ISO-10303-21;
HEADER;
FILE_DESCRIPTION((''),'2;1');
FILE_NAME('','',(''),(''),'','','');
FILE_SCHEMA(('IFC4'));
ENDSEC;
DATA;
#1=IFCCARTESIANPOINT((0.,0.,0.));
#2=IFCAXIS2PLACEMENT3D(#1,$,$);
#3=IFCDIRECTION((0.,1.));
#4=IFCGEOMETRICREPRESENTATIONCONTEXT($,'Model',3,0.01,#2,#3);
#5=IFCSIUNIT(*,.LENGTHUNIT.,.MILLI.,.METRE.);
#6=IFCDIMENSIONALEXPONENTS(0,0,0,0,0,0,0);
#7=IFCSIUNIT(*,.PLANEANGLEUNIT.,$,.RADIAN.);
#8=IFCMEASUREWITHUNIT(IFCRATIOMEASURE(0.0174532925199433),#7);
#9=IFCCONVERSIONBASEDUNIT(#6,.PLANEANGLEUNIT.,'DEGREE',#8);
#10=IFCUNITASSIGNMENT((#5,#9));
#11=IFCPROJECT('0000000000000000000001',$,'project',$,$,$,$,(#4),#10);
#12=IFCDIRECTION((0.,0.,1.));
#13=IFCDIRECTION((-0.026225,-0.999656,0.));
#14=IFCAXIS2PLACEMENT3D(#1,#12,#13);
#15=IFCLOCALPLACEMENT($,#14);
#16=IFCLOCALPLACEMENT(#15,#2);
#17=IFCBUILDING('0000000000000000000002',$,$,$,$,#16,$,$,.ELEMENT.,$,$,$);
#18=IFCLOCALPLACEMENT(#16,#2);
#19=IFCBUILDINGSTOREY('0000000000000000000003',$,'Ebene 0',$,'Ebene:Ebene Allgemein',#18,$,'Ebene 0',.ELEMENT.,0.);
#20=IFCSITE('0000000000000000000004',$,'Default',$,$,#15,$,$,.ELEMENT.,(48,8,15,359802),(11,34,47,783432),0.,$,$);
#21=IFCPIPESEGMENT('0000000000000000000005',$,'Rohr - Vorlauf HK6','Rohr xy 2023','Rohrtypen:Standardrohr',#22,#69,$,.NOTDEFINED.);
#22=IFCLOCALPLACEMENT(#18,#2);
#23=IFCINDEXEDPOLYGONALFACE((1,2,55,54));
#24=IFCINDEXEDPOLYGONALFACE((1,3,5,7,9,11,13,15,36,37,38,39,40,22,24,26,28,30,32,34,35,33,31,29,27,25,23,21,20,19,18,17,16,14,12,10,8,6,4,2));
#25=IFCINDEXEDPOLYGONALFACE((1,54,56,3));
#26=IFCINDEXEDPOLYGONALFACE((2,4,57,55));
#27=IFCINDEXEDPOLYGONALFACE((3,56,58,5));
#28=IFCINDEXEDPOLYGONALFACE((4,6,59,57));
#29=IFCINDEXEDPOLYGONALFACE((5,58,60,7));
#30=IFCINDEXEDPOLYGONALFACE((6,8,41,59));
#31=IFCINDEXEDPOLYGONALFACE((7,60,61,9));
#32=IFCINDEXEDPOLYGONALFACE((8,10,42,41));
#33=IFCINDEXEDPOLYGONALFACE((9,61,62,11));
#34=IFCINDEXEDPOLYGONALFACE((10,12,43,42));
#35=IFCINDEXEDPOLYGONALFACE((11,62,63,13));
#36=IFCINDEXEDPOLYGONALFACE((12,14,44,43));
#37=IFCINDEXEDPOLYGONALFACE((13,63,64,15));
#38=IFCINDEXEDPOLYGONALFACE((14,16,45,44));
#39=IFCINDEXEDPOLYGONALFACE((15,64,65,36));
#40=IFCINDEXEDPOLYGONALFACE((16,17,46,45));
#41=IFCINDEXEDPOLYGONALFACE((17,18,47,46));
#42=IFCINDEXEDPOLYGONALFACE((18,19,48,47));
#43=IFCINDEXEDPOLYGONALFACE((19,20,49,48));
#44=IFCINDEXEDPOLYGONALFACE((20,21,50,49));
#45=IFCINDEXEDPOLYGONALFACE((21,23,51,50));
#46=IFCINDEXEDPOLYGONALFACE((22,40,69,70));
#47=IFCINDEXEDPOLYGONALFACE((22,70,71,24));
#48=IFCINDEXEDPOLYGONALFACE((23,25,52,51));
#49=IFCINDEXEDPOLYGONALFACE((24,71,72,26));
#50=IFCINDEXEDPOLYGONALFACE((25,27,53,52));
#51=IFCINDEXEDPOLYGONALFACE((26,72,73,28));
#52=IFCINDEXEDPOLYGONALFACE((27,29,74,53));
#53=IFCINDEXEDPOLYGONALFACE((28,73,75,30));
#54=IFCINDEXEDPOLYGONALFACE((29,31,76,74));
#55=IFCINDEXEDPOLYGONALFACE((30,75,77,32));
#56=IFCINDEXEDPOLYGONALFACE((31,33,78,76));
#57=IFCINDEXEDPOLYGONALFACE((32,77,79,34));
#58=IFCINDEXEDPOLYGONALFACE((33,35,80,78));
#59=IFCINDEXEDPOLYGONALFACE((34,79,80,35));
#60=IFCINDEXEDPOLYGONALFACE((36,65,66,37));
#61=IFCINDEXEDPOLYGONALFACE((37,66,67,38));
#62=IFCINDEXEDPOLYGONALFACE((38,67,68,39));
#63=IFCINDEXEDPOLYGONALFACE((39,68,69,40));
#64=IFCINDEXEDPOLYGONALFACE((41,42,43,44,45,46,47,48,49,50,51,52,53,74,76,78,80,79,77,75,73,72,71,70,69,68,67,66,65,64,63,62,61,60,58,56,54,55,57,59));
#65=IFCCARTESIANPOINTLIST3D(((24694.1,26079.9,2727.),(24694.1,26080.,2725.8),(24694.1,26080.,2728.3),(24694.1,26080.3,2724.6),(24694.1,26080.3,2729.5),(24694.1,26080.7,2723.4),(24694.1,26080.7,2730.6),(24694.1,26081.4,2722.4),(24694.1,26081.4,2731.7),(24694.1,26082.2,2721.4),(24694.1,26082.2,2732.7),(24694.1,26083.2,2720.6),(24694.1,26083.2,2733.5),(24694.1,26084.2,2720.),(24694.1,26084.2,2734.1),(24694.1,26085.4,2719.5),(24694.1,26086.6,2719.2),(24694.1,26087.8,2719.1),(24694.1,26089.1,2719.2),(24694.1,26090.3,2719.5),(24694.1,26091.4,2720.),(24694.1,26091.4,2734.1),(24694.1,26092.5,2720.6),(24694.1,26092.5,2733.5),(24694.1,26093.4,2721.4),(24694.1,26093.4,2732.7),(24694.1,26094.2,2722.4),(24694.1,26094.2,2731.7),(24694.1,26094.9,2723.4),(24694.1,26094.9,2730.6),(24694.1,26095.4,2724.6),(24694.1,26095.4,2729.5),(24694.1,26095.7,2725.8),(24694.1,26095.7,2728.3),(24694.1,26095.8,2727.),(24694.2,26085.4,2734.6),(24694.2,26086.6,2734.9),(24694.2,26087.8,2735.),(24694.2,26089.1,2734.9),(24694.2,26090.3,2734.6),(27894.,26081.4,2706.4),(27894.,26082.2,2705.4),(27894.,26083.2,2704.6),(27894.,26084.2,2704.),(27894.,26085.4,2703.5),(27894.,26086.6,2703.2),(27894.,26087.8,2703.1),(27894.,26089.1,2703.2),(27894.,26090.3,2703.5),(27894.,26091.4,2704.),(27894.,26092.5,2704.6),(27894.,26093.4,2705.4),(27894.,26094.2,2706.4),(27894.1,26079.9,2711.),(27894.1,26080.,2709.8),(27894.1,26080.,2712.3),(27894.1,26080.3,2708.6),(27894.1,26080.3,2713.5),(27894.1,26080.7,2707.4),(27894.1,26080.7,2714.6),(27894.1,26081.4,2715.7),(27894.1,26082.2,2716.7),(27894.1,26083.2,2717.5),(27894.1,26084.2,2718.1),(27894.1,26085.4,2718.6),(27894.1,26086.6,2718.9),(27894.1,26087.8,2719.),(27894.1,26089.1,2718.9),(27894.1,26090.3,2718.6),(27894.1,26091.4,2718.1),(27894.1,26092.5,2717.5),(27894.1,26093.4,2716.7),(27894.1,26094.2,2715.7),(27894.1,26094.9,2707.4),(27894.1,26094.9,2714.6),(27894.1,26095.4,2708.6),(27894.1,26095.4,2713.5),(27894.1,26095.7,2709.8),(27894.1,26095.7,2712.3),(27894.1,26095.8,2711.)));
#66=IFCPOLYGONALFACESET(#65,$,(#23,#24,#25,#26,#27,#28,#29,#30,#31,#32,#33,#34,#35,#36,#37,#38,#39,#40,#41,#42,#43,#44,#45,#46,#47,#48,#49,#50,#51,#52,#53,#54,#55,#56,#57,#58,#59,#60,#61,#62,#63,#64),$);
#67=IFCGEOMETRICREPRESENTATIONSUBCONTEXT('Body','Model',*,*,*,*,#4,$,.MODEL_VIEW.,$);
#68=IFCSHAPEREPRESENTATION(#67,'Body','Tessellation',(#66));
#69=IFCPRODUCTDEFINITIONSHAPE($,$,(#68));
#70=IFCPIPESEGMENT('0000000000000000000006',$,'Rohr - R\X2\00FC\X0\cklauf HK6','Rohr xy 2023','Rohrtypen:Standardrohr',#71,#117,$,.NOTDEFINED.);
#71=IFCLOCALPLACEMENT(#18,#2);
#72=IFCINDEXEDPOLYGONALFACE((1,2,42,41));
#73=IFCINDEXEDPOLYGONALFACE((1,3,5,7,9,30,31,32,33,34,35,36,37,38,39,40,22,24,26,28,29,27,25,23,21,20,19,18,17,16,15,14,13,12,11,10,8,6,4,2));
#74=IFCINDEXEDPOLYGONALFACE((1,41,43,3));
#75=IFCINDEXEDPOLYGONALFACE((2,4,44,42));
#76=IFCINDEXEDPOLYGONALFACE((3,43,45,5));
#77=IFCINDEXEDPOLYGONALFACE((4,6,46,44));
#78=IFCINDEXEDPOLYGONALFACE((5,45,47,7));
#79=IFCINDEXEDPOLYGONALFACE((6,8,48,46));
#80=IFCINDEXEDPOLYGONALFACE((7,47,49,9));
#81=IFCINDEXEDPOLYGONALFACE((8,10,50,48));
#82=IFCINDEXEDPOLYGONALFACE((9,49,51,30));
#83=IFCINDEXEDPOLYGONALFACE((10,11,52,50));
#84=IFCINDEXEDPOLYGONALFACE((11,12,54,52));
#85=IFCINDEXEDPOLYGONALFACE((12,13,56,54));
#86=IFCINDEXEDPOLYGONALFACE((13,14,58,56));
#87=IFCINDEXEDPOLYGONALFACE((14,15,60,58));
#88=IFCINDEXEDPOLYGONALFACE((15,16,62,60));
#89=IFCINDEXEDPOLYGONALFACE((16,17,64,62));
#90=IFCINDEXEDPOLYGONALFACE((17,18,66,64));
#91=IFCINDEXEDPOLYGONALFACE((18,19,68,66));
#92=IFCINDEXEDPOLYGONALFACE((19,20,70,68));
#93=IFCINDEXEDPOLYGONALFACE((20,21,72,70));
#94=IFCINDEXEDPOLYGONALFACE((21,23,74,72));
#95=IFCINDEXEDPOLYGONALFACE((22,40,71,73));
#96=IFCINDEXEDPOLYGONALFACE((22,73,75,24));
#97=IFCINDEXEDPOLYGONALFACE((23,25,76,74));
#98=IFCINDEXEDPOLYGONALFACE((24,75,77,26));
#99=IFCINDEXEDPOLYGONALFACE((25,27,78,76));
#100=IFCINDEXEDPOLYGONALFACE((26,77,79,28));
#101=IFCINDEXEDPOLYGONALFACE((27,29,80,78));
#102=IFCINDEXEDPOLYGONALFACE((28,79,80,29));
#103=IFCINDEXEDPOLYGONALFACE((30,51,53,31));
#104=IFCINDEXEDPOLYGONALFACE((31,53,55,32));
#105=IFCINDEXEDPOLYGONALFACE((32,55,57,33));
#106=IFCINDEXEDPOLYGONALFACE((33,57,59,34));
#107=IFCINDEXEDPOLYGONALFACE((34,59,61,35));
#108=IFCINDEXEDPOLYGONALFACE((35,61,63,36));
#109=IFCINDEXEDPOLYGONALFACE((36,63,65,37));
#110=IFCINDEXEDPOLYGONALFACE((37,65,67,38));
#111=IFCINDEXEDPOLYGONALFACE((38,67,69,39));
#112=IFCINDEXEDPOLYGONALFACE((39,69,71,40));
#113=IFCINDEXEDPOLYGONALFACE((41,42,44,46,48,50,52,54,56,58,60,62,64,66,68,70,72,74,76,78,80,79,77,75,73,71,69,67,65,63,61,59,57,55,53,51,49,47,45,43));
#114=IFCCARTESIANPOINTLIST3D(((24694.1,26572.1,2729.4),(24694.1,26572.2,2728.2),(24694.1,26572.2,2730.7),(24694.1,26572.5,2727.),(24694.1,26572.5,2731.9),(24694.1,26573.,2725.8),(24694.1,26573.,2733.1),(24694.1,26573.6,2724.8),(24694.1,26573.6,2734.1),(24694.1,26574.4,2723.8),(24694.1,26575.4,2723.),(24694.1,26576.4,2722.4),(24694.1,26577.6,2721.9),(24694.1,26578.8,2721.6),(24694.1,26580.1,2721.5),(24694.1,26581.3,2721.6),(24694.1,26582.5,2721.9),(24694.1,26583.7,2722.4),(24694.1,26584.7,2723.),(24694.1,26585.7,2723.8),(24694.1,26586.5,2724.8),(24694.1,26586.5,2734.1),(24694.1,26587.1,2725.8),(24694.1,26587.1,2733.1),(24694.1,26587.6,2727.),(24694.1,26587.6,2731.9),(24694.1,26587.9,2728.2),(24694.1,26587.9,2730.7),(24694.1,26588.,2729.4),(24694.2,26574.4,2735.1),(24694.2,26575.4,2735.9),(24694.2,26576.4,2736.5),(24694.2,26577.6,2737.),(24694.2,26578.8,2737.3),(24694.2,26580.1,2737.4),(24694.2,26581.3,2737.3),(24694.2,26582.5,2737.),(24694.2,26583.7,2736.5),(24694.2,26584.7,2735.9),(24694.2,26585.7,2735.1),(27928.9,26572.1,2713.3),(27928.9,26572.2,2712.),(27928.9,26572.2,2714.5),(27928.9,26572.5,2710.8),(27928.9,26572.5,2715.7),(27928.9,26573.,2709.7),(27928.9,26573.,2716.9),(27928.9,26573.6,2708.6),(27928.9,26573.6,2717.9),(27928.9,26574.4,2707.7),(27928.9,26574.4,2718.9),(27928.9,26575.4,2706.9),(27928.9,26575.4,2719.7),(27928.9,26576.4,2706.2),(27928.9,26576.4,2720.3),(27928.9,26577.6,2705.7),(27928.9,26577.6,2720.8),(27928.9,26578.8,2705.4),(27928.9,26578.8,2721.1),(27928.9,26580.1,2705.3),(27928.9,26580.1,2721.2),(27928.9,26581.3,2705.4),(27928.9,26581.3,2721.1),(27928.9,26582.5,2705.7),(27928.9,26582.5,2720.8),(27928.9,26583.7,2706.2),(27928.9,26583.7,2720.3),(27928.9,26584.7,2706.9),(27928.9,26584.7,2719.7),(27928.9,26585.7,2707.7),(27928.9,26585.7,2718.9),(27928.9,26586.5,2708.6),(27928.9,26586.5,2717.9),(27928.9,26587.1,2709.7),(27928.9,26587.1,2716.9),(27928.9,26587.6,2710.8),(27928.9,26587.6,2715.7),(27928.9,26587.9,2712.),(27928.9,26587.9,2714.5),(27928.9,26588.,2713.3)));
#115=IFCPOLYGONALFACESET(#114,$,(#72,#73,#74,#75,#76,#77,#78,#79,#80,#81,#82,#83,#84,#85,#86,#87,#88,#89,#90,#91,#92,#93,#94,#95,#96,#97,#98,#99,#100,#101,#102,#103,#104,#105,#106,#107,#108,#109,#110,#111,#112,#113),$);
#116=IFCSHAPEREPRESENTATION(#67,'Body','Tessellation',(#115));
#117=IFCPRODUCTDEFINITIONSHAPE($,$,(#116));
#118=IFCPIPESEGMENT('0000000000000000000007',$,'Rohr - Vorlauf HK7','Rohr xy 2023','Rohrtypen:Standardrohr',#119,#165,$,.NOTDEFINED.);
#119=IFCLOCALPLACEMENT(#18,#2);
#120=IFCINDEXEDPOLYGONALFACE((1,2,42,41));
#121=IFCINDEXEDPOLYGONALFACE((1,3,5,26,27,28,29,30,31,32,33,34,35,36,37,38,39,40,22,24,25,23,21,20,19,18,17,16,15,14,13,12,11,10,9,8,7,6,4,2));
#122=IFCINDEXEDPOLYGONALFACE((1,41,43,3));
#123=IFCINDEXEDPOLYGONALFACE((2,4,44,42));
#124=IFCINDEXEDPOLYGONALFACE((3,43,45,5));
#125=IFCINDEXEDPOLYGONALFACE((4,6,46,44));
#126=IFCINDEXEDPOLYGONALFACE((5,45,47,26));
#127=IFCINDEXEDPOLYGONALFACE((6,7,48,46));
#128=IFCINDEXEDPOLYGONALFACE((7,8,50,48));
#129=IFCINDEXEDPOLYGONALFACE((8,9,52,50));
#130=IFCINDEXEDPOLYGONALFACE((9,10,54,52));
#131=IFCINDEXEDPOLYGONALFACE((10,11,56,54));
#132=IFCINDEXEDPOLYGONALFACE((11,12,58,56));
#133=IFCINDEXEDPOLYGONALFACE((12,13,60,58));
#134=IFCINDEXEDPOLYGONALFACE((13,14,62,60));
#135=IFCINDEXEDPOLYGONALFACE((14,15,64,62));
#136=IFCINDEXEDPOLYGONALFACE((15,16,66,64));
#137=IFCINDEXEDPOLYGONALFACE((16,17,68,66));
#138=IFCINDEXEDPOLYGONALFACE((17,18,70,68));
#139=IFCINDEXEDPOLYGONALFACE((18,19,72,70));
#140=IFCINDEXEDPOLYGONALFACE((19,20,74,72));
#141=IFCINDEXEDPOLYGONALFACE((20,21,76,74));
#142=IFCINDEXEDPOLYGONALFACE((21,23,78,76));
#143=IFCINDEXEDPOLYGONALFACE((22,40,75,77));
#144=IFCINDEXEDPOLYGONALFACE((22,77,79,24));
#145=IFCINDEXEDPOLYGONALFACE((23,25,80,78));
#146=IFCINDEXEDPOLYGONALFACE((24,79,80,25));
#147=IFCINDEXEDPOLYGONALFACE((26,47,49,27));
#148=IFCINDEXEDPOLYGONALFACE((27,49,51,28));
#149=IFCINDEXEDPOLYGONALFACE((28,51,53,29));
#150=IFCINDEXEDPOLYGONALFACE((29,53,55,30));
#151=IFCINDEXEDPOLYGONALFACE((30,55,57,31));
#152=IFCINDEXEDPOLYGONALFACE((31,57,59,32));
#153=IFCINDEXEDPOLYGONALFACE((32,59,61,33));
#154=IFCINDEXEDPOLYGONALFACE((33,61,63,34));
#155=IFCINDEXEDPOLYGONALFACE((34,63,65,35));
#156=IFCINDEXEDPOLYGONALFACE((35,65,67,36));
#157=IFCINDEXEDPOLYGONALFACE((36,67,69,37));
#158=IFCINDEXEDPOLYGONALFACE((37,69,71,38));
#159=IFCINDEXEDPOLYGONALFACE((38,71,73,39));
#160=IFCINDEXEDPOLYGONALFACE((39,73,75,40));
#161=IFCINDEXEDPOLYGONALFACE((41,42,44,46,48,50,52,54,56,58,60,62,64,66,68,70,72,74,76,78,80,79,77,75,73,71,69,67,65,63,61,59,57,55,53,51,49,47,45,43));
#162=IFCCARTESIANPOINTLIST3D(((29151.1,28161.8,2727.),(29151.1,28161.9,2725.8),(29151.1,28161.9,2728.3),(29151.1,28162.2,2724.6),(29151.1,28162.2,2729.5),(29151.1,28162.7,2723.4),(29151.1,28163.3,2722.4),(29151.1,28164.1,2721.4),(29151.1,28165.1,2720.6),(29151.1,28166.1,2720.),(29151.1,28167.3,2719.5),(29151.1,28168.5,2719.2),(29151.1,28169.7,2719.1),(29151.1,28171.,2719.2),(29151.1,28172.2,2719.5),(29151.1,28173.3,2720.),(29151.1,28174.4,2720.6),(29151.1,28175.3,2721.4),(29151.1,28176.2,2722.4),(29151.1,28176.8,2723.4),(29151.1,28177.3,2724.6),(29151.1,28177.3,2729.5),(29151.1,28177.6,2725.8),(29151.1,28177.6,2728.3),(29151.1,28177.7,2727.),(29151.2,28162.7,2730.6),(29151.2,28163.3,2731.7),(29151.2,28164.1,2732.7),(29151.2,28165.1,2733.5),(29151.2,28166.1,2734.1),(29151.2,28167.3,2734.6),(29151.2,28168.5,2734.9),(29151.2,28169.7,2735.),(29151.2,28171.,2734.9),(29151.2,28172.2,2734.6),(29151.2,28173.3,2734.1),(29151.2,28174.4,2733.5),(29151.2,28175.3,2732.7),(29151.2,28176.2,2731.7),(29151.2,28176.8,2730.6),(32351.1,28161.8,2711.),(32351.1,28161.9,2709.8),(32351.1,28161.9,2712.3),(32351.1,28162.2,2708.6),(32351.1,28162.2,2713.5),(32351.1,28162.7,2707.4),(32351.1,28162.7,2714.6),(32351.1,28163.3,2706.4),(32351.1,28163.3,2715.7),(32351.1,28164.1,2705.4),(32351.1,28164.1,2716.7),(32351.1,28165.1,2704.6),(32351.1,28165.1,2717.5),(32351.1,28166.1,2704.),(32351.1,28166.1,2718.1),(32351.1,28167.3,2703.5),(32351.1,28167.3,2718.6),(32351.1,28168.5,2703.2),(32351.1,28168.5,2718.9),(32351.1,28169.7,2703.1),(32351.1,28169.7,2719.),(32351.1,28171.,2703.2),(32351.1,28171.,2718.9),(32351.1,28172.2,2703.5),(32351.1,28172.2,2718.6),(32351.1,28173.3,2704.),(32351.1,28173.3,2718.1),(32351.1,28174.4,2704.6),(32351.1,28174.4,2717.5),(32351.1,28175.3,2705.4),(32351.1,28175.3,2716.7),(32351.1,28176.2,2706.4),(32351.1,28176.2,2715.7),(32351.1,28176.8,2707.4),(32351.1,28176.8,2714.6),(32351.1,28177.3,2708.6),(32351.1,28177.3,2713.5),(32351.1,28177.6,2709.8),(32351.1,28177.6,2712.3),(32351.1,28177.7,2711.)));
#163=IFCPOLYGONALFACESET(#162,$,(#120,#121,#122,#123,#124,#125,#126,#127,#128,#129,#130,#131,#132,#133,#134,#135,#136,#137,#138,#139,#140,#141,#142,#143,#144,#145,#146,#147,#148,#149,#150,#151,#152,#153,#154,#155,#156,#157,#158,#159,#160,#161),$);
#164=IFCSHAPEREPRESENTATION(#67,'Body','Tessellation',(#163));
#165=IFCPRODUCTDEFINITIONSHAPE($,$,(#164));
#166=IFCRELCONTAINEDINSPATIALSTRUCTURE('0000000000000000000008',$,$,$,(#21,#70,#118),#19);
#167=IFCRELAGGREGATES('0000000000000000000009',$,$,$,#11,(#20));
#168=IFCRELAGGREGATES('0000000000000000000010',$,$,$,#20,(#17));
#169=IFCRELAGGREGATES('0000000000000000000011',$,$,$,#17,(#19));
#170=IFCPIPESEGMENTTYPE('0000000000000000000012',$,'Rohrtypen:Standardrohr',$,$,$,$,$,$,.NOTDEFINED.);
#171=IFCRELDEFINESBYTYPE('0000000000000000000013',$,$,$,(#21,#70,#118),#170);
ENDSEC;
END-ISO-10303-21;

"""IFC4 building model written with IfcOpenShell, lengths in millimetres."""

from ifc_helpers import new_model, entity, si_unit, converted_unit, direction, frame, origin, place, context, subcontext, project, spatial, indexed_curve, outline, extrude, type_object, element, save


model = new_model("IFC4")

# Units and contexts
model_context = context("Model", 3, precision=0.01, world=origin(), true_north=direction((0.0, 1.0)))
body_context = subcontext(model_context, "Body", "Model", "MODEL_VIEW")
ifc_project = project(units=[si_unit("LENGTHUNIT", "METRE", prefix="MILLI"), converted_unit("PLANEANGLEUNIT", "DEGREE", entity("IfcRatioMeasure", 0.0174532925199433), si_unit("PLANEANGLEUNIT", "RADIAN"), dimensions=[0, 0, 0, 0, 0, 0, 0])], contexts=[model_context])

# Site, building, storey
site_placement = place(None, frame((0.0, 0.0, 0.0), z_axis=(0.0, 0.0, 1.0), x_axis=(-0.026225, -0.999656, 0.0)))
site = spatial("IfcSite", under=ifc_project, at=site_placement, Name="Default", CompositionType="ELEMENT", RefLatitude=(48, 8, 15, 359802), RefLongitude=(11, 34, 47, 783432), RefElevation=0.0)
building_placement = place(site_placement, origin())
building = spatial("IfcBuilding", under=site, at=building_placement, CompositionType="ELEMENT")
storey_placement = place(building_placement, origin())
storey = spatial("IfcBuildingStorey", under=building, at=storey_placement, Name="Ebene 0", ObjectType="Ebene:Ebene Allgemein", LongName="Ebene 0", CompositionType="ELEMENT", Elevation=0.0)

# Pipe segments
pipe_segment_type = type_object("IfcPipeSegmentType", Name="Rohrtypen:Standardrohr", PredefinedType="NOTDEFINED")
pipe_segment_1_placement = place(storey_placement, origin())
element("IfcPipeSegment", 1, at=pipe_segment_1_placement, inside=storey, type_object=pipe_segment_type, Name="Rohr - Vorlauf HK6", Description="Rohr xy 2023", ObjectType="Rohrtypen:Standardrohr", PredefinedType="NOTDEFINED", context=body_context, shape_type="SweptSolid", body=[
    extrude(outline(indexed_curve([(7.9, 0.0), (7.8, 1.2), (7.6, 2.5), (7.1, 3.6), (6.4, 4.7), (5.6, 5.6), (4.7, 6.4), (3.6, 7.1), (2.5, 7.6), (1.2, 7.8), (0.0, 7.9), (-1.2, 7.8), (-2.5, 7.6), (-3.6, 7.1), (-4.7, 6.4), (-5.6, 5.6), (-6.4, 4.7), (-7.1, 3.6), (-7.6, 2.5), (-7.8, 1.2), (-7.9, 0.0), (-7.8, -1.2), (-7.6, -2.5), (-7.1, -3.6), (-6.4, -4.7), (-5.6, -5.6), (-4.7, -6.4), (-3.6, -7.1), (-2.5, -7.6), (-1.2, -7.8), (0.0, -7.9), (1.2, -7.8), (2.5, -7.6), (3.6, -7.1), (4.7, -6.4), (5.6, -5.6), (6.4, -4.7), (7.1, -3.6), (7.6, -2.5), (7.8, -1.2), (7.9, 0.0)], self_intersect=False)), frame((27894.1, 26087.8, 2711.0), z_axis=(-0.999988, 0.0, 0.005), x_axis=(0.0, 1.0, 0.0)), (0.0, 0.0, 1.0), 3200.0),
])
pipe_segment_2_placement = place(storey_placement, origin())
element("IfcPipeSegment", 2, at=pipe_segment_2_placement, inside=storey, type_object=pipe_segment_type, Name="Rohr - Rücklauf HK6", Description="Rohr xy 2023", ObjectType="Rohrtypen:Standardrohr", PredefinedType="NOTDEFINED", context=body_context, shape_type="SweptSolid", body=[
    extrude(outline(indexed_curve([(7.9, 0.0), (7.8, 1.2), (7.6, 2.5), (7.1, 3.6), (6.4, 4.7), (5.6, 5.6), (4.7, 6.4), (3.6, 7.1), (2.5, 7.6), (1.2, 7.8), (0.0, 7.9), (-1.2, 7.8), (-2.5, 7.6), (-3.6, 7.1), (-4.7, 6.4), (-5.6, 5.6), (-6.4, 4.7), (-7.1, 3.6), (-7.6, 2.5), (-7.8, 1.2), (-7.9, 0.0), (-7.8, -1.2), (-7.6, -2.5), (-7.1, -3.6), (-6.4, -4.7), (-5.6, -5.6), (-4.7, -6.4), (-3.6, -7.1), (-2.5, -7.6), (-1.2, -7.8), (0.0, -7.9), (1.2, -7.8), (2.5, -7.6), (3.6, -7.1), (4.7, -6.4), (5.6, -5.6), (6.4, -4.7), (7.1, -3.6), (7.6, -2.5), (7.8, -1.2), (7.9, 0.0)], self_intersect=False)), frame((27928.9, 26580.1, 2713.3), z_axis=(-0.999988, 0.0, 0.005), x_axis=(0.0, 1.0, 0.0)), (0.0, 0.0, 1.0), 3234.8),
])
pipe_segment_3_placement = place(storey_placement, origin())
element("IfcPipeSegment", 3, at=pipe_segment_3_placement, inside=storey, type_object=pipe_segment_type, Name="Rohr - Vorlauf HK7", Description="Rohr xy 2023", ObjectType="Rohrtypen:Standardrohr", PredefinedType="NOTDEFINED", context=body_context, shape_type="SweptSolid", body=[
    extrude(outline(indexed_curve([(7.9, 0.0), (7.8, 1.2), (7.6, 2.5), (7.1, 3.6), (6.4, 4.7), (5.6, 5.6), (4.7, 6.4), (3.6, 7.1), (2.5, 7.6), (1.2, 7.8), (0.0, 7.9), (-1.2, 7.8), (-2.5, 7.6), (-3.6, 7.1), (-4.7, 6.4), (-5.6, 5.6), (-6.4, 4.7), (-7.1, 3.6), (-7.6, 2.5), (-7.8, 1.2), (-7.9, 0.0), (-7.8, -1.2), (-7.6, -2.5), (-7.1, -3.6), (-6.4, -4.7), (-5.6, -5.6), (-4.7, -6.4), (-3.6, -7.1), (-2.5, -7.6), (-1.2, -7.8), (0.0, -7.9), (1.2, -7.8), (2.5, -7.6), (3.6, -7.1), (4.7, -6.4), (5.6, -5.6), (6.4, -4.7), (7.1, -3.6), (7.6, -2.5), (7.8, -1.2), (7.9, 0.0)], self_intersect=False)), frame((32351.1, 28169.7, 2711.0), z_axis=(-0.999988, 0.0, 0.005), x_axis=(0.0, 1.0, 0.0)), (0.0, 0.0, 1.0), 3200.0),
])

save(model, "model.ifc")
